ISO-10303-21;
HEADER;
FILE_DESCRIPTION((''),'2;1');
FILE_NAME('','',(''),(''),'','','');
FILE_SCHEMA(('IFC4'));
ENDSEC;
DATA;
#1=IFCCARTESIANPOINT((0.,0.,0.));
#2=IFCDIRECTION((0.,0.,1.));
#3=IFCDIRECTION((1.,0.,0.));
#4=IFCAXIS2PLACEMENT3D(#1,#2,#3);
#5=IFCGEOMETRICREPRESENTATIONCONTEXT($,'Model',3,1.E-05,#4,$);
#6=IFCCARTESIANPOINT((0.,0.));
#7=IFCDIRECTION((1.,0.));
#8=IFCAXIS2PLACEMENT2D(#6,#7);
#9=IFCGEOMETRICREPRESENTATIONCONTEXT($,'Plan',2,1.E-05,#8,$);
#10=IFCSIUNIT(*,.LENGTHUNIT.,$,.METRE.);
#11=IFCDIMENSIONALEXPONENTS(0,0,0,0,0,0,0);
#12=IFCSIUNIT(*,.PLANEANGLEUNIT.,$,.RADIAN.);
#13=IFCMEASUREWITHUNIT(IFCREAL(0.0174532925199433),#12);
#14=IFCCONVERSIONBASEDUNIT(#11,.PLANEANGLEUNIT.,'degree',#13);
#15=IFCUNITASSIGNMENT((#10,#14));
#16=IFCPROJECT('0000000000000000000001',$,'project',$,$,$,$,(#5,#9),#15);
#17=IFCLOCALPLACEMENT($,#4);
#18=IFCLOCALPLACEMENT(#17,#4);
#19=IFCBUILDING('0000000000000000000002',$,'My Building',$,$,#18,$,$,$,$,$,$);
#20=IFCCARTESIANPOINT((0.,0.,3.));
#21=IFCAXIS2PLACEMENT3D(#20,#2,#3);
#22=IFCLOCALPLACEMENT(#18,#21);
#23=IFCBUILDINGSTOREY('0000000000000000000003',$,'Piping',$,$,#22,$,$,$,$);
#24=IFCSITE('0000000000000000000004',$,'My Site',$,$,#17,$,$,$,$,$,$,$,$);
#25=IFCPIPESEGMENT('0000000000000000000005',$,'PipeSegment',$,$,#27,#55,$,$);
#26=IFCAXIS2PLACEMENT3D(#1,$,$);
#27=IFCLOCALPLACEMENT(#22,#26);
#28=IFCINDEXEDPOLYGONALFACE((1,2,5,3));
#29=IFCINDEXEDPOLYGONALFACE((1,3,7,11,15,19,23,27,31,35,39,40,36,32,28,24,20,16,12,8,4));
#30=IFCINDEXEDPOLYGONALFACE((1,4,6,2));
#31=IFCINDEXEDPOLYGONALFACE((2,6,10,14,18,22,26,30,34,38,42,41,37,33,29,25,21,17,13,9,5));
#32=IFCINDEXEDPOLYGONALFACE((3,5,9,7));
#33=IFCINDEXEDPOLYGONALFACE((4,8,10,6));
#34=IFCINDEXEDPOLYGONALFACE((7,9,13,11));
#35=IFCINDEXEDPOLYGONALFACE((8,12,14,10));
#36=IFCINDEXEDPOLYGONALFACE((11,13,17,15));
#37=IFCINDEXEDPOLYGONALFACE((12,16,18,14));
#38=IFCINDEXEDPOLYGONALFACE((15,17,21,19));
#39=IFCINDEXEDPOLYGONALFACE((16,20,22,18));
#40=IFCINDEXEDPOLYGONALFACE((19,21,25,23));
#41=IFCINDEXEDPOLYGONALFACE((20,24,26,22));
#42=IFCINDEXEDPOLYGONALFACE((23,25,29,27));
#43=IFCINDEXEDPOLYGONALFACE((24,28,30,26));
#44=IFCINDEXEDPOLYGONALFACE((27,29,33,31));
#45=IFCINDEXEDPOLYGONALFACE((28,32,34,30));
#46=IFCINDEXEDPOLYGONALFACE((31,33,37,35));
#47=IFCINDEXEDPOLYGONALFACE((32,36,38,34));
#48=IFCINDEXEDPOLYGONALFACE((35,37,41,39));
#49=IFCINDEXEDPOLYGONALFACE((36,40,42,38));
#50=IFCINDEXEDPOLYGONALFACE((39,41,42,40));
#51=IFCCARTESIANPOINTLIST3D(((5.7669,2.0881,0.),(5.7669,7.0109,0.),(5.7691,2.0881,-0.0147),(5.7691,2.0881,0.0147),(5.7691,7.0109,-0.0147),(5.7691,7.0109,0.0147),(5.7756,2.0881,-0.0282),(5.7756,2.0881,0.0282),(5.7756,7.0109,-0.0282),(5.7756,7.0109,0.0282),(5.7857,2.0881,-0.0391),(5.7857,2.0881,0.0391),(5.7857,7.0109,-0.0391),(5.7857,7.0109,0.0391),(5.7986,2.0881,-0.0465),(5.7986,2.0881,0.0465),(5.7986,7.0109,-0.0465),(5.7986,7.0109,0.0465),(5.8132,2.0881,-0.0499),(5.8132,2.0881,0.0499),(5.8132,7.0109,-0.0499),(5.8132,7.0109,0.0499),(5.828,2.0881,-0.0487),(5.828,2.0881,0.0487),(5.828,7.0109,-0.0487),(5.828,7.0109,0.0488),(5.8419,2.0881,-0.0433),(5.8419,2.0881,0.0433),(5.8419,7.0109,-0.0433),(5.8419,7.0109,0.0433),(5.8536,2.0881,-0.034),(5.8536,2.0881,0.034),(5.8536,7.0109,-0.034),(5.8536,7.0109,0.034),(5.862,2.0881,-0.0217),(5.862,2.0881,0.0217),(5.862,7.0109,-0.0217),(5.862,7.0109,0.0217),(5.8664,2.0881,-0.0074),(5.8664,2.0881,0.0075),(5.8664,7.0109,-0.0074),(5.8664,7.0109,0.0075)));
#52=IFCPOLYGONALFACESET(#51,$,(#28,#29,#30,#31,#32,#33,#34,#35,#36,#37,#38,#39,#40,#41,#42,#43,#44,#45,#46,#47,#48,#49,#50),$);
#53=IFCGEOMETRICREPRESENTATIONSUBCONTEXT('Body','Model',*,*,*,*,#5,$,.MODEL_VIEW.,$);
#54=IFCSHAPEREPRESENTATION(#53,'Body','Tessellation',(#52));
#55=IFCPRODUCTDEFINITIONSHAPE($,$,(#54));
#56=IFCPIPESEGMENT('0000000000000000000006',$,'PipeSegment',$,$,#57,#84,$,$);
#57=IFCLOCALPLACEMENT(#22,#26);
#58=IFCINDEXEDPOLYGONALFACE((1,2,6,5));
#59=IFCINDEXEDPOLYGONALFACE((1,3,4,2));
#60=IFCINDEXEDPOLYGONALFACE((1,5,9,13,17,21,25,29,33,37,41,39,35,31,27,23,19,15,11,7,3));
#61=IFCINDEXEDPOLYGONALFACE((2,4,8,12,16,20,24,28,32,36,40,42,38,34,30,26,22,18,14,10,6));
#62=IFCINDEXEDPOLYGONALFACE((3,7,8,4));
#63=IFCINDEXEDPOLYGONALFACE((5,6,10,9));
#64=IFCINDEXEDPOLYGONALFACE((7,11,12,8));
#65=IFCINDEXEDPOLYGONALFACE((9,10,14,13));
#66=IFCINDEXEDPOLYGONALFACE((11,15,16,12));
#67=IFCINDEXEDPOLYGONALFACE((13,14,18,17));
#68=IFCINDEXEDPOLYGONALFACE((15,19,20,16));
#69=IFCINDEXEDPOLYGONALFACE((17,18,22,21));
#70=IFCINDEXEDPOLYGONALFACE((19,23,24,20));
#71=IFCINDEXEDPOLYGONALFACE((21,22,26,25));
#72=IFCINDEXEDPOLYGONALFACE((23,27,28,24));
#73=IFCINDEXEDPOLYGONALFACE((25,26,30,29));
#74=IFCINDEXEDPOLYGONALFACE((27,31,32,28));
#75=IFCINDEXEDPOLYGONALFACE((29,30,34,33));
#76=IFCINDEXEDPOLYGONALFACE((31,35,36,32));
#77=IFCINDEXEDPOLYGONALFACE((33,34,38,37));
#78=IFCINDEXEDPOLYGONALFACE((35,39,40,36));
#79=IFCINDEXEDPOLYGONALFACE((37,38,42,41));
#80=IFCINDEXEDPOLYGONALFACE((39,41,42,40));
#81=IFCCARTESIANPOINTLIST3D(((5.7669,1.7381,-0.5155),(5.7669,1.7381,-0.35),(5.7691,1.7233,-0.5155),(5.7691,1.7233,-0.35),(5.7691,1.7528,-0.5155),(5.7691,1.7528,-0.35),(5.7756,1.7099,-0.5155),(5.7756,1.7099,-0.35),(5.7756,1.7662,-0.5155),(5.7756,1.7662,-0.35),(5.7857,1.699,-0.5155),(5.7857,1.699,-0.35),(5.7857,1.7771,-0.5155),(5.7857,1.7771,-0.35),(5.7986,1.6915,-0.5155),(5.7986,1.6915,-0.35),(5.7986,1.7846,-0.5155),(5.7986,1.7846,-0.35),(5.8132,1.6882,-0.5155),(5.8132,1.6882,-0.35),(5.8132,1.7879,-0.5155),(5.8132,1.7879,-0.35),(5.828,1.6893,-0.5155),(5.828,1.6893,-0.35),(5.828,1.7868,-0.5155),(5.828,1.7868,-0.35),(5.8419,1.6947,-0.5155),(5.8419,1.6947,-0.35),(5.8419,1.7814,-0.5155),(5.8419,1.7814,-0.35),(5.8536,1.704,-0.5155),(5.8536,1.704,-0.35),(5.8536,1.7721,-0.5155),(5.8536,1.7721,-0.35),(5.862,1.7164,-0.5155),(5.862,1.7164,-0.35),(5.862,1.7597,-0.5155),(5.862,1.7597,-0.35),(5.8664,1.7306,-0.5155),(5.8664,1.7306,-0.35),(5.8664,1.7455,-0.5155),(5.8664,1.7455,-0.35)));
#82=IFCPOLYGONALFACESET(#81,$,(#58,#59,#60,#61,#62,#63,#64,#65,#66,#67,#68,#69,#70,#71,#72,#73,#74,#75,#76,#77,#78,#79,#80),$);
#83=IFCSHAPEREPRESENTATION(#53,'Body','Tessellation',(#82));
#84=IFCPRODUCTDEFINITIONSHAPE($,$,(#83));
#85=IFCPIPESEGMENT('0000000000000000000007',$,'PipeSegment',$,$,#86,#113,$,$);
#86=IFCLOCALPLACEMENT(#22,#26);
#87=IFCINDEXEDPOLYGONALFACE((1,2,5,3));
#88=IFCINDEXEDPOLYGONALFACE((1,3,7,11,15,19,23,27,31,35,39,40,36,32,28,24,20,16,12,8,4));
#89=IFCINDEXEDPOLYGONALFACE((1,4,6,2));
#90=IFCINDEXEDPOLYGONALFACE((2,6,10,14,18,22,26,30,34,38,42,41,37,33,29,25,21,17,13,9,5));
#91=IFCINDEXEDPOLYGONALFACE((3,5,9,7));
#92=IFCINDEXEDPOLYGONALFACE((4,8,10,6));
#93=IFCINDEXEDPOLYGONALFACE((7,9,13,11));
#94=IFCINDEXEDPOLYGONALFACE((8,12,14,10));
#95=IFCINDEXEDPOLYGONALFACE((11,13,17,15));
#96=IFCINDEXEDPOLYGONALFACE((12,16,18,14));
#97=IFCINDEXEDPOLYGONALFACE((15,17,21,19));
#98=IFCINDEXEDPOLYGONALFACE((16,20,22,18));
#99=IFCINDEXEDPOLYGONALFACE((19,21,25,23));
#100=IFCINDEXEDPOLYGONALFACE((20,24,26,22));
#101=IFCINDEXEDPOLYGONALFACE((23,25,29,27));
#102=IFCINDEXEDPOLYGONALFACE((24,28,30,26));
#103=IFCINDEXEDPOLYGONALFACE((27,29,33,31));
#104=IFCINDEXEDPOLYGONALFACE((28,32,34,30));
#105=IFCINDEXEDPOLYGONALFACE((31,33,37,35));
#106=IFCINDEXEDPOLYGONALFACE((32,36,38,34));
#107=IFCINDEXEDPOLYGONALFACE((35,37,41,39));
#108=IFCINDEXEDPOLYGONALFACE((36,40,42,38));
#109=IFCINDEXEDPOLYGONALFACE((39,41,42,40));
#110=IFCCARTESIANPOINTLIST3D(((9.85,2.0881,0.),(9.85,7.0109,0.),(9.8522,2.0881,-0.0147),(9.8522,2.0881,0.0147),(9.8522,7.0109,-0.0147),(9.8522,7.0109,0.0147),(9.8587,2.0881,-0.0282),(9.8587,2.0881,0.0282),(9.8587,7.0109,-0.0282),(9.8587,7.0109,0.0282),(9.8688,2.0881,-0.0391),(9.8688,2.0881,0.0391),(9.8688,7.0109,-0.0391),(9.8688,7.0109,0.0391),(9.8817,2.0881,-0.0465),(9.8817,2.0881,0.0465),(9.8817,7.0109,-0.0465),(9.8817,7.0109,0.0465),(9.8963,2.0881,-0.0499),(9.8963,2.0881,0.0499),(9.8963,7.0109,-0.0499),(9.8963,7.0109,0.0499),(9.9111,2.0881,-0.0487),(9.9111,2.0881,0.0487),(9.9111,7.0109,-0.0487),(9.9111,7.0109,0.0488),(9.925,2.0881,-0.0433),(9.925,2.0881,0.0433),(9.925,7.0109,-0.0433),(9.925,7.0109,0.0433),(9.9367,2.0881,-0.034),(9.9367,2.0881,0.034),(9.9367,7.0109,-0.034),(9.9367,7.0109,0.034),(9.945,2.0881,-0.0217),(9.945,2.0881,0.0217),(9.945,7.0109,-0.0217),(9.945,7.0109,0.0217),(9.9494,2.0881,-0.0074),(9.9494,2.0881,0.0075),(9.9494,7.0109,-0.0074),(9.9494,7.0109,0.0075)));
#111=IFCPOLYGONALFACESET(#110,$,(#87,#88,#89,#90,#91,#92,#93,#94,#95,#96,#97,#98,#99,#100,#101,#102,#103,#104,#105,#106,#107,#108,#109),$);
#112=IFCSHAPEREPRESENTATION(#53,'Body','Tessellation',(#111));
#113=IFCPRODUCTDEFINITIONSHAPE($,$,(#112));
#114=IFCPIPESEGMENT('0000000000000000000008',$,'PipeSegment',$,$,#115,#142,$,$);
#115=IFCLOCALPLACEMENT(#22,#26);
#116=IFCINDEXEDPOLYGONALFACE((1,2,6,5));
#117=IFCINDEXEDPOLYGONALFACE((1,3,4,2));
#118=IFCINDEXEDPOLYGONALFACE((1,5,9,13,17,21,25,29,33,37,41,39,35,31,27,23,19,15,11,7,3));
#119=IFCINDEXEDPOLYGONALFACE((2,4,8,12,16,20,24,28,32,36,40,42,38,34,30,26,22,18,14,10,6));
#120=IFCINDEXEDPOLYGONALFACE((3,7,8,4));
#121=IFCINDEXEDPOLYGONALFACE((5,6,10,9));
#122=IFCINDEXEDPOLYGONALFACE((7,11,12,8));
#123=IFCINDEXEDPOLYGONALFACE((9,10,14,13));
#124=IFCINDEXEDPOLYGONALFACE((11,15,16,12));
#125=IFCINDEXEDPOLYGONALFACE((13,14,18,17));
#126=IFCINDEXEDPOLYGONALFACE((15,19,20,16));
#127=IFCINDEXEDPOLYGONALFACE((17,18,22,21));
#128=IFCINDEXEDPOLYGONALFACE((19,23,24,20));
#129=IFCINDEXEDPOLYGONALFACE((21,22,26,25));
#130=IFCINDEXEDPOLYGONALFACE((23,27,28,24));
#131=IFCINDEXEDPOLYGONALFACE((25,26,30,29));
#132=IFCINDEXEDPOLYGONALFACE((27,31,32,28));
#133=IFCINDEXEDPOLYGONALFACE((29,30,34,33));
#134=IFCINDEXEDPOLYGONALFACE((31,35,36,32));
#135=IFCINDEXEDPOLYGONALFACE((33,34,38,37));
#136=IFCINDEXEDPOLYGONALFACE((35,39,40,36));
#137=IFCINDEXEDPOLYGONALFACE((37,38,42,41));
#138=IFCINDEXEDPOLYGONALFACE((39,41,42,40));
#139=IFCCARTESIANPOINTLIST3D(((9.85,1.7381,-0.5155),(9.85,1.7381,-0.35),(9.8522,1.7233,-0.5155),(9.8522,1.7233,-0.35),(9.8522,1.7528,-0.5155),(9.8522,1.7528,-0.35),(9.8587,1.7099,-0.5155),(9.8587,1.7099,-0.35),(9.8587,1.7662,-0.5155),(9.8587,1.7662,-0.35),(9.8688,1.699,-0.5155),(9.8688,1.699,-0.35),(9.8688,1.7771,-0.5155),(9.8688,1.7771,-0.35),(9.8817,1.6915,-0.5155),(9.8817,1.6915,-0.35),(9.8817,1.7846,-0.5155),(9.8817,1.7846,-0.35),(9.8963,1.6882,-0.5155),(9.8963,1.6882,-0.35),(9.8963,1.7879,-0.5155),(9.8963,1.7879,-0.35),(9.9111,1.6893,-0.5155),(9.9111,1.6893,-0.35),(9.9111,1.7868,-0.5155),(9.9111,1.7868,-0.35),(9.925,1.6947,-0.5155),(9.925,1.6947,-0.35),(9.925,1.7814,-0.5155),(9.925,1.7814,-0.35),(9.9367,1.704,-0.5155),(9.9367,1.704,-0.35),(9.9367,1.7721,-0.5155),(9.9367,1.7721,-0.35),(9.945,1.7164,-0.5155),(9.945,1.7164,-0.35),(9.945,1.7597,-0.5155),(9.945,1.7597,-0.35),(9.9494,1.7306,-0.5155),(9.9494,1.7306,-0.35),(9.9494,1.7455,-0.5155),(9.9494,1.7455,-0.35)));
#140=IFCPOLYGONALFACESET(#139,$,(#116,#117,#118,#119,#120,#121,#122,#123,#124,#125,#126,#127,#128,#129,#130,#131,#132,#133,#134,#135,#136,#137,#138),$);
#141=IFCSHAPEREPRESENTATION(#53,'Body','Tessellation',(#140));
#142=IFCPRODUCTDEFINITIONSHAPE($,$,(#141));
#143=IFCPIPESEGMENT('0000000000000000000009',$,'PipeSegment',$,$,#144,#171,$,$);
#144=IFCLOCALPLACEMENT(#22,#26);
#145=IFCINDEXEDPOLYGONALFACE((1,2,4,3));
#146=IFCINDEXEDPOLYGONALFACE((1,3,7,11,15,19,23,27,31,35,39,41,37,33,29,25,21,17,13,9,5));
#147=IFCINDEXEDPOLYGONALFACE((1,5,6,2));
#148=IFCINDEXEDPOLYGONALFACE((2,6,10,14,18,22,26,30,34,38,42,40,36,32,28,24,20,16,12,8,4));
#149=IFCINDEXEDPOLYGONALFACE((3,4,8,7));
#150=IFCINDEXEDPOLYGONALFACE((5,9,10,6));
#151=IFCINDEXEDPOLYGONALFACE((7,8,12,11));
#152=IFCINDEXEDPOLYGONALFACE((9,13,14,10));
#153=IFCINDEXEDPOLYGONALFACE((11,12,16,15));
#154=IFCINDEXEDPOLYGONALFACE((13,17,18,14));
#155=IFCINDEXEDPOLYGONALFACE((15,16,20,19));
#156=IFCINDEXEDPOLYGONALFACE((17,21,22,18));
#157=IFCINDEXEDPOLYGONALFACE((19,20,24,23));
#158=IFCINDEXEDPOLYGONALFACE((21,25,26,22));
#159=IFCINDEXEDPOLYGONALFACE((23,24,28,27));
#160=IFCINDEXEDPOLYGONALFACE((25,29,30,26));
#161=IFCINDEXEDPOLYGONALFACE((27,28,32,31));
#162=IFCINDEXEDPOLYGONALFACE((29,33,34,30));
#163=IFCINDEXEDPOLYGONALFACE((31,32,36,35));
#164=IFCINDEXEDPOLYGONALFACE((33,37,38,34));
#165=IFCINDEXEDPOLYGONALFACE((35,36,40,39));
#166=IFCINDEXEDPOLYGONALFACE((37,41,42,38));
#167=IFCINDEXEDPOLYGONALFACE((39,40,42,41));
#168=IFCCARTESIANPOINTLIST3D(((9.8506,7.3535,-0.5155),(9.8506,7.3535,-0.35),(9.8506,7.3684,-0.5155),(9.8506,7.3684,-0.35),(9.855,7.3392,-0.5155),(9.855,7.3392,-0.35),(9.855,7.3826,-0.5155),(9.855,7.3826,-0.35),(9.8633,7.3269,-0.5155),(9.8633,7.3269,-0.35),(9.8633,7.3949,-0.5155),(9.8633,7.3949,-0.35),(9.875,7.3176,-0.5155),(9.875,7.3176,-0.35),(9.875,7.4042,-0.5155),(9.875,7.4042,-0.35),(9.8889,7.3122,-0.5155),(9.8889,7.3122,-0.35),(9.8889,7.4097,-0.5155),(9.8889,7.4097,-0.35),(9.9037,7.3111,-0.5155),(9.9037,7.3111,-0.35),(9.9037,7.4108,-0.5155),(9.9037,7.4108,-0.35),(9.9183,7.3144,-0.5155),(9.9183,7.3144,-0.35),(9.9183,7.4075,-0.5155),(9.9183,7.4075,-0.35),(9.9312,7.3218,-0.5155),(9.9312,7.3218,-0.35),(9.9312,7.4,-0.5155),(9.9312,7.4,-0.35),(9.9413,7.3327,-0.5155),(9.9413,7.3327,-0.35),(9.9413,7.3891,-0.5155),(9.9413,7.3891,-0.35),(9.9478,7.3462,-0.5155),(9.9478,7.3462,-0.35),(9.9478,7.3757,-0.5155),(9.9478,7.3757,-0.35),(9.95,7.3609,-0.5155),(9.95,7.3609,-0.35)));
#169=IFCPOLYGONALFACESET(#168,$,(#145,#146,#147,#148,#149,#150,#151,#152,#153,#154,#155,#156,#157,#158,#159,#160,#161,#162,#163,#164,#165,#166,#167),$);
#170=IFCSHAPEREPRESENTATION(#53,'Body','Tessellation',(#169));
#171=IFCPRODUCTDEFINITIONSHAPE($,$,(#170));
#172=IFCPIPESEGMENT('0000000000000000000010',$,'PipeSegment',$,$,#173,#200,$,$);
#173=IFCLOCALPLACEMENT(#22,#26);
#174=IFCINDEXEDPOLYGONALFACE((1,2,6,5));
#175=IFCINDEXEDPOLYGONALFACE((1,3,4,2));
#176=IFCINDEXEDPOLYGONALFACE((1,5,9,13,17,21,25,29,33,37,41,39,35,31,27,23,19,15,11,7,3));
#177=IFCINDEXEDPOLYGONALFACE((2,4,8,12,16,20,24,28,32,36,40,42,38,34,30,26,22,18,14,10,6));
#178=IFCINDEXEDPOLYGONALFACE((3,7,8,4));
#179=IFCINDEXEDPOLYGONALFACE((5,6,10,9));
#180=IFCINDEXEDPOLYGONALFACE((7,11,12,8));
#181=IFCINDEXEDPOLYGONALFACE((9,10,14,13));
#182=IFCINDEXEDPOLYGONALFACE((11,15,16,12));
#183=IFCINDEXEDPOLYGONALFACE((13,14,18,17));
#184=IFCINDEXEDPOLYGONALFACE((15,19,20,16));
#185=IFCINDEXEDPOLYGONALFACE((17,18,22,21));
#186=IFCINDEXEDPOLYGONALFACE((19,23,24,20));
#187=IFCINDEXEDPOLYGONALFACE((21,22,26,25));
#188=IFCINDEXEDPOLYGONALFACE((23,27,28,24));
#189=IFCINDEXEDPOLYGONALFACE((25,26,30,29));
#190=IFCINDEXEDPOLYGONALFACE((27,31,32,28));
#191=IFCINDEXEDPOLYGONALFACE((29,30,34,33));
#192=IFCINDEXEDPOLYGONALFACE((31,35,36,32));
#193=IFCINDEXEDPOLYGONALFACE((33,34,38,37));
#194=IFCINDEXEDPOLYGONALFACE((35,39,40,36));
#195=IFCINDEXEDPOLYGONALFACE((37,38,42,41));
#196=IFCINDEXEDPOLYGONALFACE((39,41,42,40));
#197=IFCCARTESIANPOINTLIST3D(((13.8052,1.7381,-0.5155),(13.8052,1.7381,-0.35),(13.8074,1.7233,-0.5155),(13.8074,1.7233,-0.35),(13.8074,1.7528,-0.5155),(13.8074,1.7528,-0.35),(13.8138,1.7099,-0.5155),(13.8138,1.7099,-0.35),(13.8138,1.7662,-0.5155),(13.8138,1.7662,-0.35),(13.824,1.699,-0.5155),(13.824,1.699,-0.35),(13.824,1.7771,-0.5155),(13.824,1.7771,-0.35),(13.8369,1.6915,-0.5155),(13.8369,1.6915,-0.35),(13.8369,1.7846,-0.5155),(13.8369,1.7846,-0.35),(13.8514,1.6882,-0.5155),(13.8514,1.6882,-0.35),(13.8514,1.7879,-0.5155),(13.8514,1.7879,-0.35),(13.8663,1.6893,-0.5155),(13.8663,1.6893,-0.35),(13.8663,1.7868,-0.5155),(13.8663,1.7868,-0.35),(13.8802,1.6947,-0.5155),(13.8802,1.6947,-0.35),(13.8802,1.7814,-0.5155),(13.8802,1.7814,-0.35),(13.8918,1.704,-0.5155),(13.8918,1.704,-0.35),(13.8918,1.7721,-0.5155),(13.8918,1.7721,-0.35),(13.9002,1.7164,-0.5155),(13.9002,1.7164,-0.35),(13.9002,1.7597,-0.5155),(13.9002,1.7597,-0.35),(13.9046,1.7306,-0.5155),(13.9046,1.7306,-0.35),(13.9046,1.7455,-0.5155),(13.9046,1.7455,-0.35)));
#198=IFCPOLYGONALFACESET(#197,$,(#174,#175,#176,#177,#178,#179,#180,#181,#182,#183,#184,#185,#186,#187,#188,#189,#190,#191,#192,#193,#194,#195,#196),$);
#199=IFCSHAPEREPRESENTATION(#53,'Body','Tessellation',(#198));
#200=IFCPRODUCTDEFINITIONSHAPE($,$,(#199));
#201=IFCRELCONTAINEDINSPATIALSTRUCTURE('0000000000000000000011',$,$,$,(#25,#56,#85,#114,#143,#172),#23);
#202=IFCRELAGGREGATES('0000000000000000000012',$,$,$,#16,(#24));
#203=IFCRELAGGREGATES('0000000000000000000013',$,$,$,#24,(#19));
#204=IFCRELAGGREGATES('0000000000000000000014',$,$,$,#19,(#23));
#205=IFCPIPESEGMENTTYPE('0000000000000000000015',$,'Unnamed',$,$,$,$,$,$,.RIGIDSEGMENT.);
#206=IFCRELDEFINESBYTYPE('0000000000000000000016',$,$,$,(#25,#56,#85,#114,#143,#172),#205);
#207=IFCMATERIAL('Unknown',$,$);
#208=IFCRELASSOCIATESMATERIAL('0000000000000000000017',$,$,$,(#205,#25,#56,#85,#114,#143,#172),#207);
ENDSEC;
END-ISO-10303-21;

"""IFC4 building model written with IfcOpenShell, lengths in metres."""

from ifc_helpers import new_model, entity, si_unit, converted_unit, frame, origin_with_axes, origin_2d_with_axis, place, context, subcontext, project, spatial, circle, extrude, material, material_profile, profile_set, profile_usage, type_object, element, save


model = new_model("IFC4")

# Units and contexts
model_context = context("Model", 3, precision=1e-05, world=origin_with_axes())
plan_context = context("Plan", 2, precision=1e-05, world=origin_2d_with_axis())
body_context = subcontext(model_context, "Body", "Model", "MODEL_VIEW")
ifc_project = project(units=[si_unit("LENGTHUNIT", "METRE"), converted_unit("PLANEANGLEUNIT", "degree", entity("IfcReal", 0.0174532925199433), si_unit("PLANEANGLEUNIT", "RADIAN"), dimensions=[0, 0, 0, 0, 0, 0, 0])], contexts=[model_context, plan_context])

# Site, building, storey
site_placement = place(None, origin_with_axes())
site = spatial("IfcSite", under=ifc_project, at=site_placement, Name="My Site")
building_placement = place(site_placement, origin_with_axes())
building = spatial("IfcBuilding", under=site, at=building_placement, Name="My Building")
storey_placement = place(building_placement, frame((0.0, 0.0, 3.0), z_axis=(0.0, 0.0, 1.0), x_axis=(1.0, 0.0, 0.0)))
storey = spatial("IfcBuildingStorey", under=building, at=storey_placement, Name="Piping")

# Pipe segments
ifc_material = material(Name="Unknown")
ifc_material_profile = material_profile(ifc_material, circle(Radius=0.05))
ifc_profile_set = profile_set([ifc_material_profile])
pipe_segment_type = type_object("IfcPipeSegmentType", Name="Unnamed", PredefinedType="RIGIDSEGMENT", material=ifc_profile_set)
ifc_profile_usage_1 = profile_usage(ifc_profile_set, cardinal=5)
pipe_segment_1_placement = place(storey_placement, frame((5.8169, 2.0881, 0.0), z_axis=(0.0, 1.0, 0.0), x_axis=(-1.0, 0.0, 0.0)))
element("IfcPipeSegment", 1, at=pipe_segment_1_placement, inside=storey, type_object=pipe_segment_type, material=ifc_profile_usage_1, Name="PipeSegment", context=body_context, shape_type="SweptSolid", body=[
    extrude(circle(Radius=0.05), origin_with_axes(), (0.0, 0.0, 1.0), 4.9229),
])
ifc_profile_usage_2 = profile_usage(ifc_profile_set, cardinal=5)
pipe_segment_2_placement = place(storey_placement, frame((5.8169, 1.7381, -0.35), z_axis=(0.0, 0.0, -1.0), x_axis=(-1.0, 0.0, 0.0)))
element("IfcPipeSegment", 2, at=pipe_segment_2_placement, inside=storey, type_object=pipe_segment_type, material=ifc_profile_usage_2, Name="PipeSegment", context=body_context, shape_type="SweptSolid", body=[
    extrude(circle(Radius=0.05), origin_with_axes(), (0.0, 0.0, 1.0), 0.1655),
])
ifc_profile_usage_3 = profile_usage(ifc_profile_set, cardinal=5)
pipe_segment_3_placement = place(storey_placement, frame((9.9, 2.0881, 0.0), z_axis=(0.0, 1.0, 0.0), x_axis=(-1.0, 0.0, 0.0)))
element("IfcPipeSegment", 3, at=pipe_segment_3_placement, inside=storey, type_object=pipe_segment_type, material=ifc_profile_usage_3, Name="PipeSegment", context=body_context, shape_type="SweptSolid", body=[
    extrude(circle(Radius=0.05), origin_with_axes(), (0.0, 0.0, 1.0), 4.9229),
])
ifc_profile_usage_4 = profile_usage(ifc_profile_set, cardinal=5)
pipe_segment_4_placement = place(storey_placement, frame((9.9, 1.7381, -0.35), z_axis=(0.0, 0.0, -1.0), x_axis=(-1.0, 0.0, 0.0)))
element("IfcPipeSegment", 4, at=pipe_segment_4_placement, inside=storey, type_object=pipe_segment_type, material=ifc_profile_usage_4, Name="PipeSegment", context=body_context, shape_type="SweptSolid", body=[
    extrude(circle(Radius=0.05), origin_with_axes(), (0.0, 0.0, 1.0), 0.1655),
])
ifc_profile_usage_5 = profile_usage(ifc_profile_set, cardinal=5)
pipe_segment_5_placement = place(storey_placement, frame((9.9, 7.3609, -0.35), z_axis=(0.0, 0.0, -1.0), x_axis=(1.0, 0.0, 0.0)))
element("IfcPipeSegment", 5, at=pipe_segment_5_placement, inside=storey, type_object=pipe_segment_type, material=ifc_profile_usage_5, Name="PipeSegment", context=body_context, shape_type="SweptSolid", body=[
    extrude(circle(Radius=0.05), origin_with_axes(), (0.0, 0.0, 1.0), 0.1655),
])
ifc_profile_usage_6 = profile_usage(ifc_profile_set, cardinal=5)
pipe_segment_6_placement = place(storey_placement, frame((13.8552, 1.7381, -0.35), z_axis=(0.0, 0.0, -1.0), x_axis=(-1.0, 0.0, 0.0)))
element("IfcPipeSegment", 6, at=pipe_segment_6_placement, inside=storey, type_object=pipe_segment_type, material=ifc_profile_usage_6, Name="PipeSegment", context=body_context, shape_type="SweptSolid", body=[
    extrude(circle(Radius=0.05), origin_with_axes(), (0.0, 0.0, 1.0), 0.1655),
])

save(model, "model.ifc")
